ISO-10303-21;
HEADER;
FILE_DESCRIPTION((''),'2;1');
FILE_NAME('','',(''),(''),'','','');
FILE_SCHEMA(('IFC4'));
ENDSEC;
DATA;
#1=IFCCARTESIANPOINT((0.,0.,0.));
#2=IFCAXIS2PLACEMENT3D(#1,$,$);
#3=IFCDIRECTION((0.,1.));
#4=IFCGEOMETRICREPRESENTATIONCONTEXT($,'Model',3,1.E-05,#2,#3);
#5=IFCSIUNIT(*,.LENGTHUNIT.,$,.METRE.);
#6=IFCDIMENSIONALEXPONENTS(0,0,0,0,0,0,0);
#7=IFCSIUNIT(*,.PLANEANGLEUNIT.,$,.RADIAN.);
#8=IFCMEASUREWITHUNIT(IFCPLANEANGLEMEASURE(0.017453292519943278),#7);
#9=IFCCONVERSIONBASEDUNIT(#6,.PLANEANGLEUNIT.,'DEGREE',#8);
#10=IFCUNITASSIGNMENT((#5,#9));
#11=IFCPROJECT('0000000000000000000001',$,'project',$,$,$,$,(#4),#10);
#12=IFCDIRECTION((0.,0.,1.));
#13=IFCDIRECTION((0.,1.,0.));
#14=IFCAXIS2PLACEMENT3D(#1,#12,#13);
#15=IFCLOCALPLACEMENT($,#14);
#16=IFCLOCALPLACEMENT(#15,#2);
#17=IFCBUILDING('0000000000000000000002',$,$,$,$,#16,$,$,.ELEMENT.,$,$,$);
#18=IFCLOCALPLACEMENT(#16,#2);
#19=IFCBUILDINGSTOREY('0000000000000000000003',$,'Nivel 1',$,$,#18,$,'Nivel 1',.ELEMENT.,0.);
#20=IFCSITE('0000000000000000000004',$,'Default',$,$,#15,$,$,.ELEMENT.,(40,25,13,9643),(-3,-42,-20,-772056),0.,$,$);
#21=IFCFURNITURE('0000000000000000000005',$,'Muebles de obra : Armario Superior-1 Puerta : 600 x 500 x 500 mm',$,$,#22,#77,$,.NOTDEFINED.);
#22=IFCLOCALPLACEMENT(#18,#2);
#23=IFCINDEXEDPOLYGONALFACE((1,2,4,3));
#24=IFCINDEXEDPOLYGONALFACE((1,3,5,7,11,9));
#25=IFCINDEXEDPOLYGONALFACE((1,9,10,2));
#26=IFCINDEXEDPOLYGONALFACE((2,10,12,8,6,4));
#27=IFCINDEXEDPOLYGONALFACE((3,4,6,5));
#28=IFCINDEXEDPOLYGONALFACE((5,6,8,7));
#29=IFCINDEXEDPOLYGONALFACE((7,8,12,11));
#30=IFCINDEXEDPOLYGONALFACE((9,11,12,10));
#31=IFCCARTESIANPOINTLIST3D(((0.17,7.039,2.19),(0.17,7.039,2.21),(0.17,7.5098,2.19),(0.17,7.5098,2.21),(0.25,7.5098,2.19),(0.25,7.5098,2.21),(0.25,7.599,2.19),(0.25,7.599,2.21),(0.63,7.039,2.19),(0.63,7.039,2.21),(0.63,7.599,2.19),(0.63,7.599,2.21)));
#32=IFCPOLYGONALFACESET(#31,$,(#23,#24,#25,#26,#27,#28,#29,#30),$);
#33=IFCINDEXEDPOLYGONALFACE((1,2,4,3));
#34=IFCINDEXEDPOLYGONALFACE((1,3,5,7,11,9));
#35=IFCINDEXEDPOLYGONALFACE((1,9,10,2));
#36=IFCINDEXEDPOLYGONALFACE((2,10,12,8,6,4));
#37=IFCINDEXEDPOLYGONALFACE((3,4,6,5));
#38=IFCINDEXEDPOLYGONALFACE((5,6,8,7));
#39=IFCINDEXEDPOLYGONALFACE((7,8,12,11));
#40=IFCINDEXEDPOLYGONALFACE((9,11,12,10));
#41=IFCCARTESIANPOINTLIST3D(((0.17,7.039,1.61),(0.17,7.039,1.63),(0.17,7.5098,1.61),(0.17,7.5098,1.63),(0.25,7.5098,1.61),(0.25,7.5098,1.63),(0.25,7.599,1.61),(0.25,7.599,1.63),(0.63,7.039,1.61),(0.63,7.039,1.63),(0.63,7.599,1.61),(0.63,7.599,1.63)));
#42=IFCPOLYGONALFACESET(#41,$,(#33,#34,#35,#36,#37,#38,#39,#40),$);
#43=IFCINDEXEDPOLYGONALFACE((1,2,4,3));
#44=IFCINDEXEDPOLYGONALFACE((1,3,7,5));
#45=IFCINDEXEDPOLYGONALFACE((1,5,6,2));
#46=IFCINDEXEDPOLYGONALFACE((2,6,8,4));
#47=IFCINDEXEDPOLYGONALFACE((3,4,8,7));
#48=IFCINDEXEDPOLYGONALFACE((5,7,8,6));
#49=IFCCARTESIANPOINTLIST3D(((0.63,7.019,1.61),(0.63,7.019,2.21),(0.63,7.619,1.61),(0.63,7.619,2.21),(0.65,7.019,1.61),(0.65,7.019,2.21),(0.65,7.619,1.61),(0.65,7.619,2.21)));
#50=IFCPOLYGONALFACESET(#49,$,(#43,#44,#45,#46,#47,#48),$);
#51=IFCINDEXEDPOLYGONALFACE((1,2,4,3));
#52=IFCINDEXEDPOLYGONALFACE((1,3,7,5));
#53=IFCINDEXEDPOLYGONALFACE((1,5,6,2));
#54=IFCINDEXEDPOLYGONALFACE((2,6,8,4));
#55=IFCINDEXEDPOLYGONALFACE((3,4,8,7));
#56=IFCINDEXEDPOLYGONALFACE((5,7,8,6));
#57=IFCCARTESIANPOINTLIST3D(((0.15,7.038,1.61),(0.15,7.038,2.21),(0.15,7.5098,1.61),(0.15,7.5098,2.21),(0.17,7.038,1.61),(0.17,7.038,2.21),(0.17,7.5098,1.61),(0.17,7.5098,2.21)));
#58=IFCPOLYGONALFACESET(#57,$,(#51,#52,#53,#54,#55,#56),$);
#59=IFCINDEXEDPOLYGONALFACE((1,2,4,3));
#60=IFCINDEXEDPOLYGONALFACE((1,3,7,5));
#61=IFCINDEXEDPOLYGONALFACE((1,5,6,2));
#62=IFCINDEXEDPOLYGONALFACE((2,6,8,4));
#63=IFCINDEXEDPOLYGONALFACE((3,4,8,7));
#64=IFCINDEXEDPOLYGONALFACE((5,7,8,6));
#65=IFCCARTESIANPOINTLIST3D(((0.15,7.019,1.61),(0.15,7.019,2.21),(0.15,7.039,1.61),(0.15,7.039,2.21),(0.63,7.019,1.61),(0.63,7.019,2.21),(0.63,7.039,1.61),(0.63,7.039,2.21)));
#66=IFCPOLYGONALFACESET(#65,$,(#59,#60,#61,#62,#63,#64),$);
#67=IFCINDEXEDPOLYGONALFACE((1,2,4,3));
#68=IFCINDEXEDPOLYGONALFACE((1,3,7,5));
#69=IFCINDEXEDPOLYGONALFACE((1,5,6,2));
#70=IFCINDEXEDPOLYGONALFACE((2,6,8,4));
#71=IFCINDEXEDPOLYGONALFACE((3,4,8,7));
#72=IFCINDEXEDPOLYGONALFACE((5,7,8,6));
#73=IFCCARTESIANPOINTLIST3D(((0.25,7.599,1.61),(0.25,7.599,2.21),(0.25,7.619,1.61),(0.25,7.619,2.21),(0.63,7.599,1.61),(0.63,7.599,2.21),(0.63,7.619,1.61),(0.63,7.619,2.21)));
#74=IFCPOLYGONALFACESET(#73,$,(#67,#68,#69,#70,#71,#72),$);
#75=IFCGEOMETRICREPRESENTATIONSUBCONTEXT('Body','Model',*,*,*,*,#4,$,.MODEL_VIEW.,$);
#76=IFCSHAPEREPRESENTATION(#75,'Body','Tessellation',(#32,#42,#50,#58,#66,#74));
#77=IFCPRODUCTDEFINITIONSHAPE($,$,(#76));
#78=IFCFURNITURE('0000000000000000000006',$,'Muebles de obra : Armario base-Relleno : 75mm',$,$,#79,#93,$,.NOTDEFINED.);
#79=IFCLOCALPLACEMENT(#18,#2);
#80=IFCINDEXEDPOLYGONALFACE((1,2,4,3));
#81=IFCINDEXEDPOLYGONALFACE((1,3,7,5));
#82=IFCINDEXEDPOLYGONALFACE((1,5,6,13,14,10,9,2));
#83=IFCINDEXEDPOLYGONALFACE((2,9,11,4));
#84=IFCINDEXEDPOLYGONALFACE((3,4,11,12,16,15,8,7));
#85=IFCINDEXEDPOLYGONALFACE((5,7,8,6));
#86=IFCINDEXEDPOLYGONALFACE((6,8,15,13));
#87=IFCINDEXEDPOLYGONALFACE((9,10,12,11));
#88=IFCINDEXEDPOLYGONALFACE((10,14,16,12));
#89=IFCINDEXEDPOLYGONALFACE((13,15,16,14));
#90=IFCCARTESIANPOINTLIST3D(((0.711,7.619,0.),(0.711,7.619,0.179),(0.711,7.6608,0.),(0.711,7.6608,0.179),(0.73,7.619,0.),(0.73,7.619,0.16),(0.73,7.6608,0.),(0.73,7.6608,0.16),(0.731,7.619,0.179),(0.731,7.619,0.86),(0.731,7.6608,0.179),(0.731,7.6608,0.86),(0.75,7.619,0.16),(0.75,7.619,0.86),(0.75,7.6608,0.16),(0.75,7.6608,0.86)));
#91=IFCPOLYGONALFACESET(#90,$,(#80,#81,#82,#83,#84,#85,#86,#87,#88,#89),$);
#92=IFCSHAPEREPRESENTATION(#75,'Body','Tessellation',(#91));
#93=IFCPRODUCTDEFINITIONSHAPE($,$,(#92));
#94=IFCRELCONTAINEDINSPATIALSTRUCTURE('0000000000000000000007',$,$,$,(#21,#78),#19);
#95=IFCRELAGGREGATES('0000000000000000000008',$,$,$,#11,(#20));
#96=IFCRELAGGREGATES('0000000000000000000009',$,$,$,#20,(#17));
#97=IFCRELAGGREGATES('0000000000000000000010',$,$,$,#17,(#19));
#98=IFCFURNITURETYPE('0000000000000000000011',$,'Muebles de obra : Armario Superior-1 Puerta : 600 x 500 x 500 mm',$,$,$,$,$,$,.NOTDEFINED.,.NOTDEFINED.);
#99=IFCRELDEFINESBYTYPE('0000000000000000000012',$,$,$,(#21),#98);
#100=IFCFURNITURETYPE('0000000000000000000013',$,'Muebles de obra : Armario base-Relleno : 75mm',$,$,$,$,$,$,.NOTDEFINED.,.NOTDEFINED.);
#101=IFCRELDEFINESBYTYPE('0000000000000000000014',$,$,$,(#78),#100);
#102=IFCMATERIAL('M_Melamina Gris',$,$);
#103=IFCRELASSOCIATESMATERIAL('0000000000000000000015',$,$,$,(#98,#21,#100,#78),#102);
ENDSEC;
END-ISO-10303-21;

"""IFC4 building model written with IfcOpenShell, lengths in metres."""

from ifc_helpers import new_model, entity, si_unit, converted_unit, direction, frame, origin, place, context, subcontext, project, spatial, indexed_curve, outline, extrude, source, transform, mapped, material, type_object, type_shapes, element, save


model = new_model("IFC4")

# Units and contexts
model_context = context("Model", 3, precision=1e-05, world=origin(), true_north=direction((0.0, 1.0)))
body_context = subcontext(model_context, "Body", "Model", "MODEL_VIEW")
ifc_project = project(units=[si_unit("LENGTHUNIT", "METRE"), converted_unit("PLANEANGLEUNIT", "DEGREE", entity("IfcPlaneAngleMeasure", 0.017453292519943278), si_unit("PLANEANGLEUNIT", "RADIAN"), dimensions=[0, 0, 0, 0, 0, 0, 0])], contexts=[model_context])

# Site, building, storey
site_placement = place(None, frame((0.0, 0.0, 0.0), z_axis=(0.0, 0.0, 1.0), x_axis=(0.0, 1.0, 0.0)))
site = spatial("IfcSite", under=ifc_project, at=site_placement, Name="Default", CompositionType="ELEMENT", RefLatitude=(40, 25, 13, 9643), RefLongitude=(-3, -42, -20, -772056), RefElevation=0.0)
building_placement = place(site_placement, origin())
building = spatial("IfcBuilding", under=site, at=building_placement, CompositionType="ELEMENT")
storey_placement = place(building_placement, origin())
storey = spatial("IfcBuildingStorey", under=building, at=storey_placement, Name="Nivel 1", LongName="Nivel 1", CompositionType="ELEMENT", Elevation=0.0)

# Furniture
ifc_material_1 = material(Name="M_Melamina Gris")
furniture_type_1 = type_object("IfcFurnitureType", Name="Muebles de obra : Armario Superior-1 Puerta : 600 x 500 x 500 mm", AssemblyPlace="NOTDEFINED", PredefinedType="NOTDEFINED", material=ifc_material_1)
shared_shape_1 = source(origin(), body_context, "Body", "SweptSolid", [
    extrude(outline(indexed_curve([(-0.28, -0.2164), (0.1, -0.2164), (0.1, -0.1272), (0.18, -0.1272), (0.18, 0.3436), (-0.28, 0.3436), (-0.28, -0.2164)], self_intersect=False)), frame((0.35, 7.3826, 2.19), z_axis=(0.0, 0.0, 1.0), x_axis=(-1.0, 0.0, 0.0)), (0.0, 0.0, 1.0), 0.02),
    extrude(outline(indexed_curve([(-0.28, -0.2164), (0.1, -0.2164), (0.1, -0.1272), (0.18, -0.1272), (0.18, 0.3436), (-0.28, 0.3436), (-0.28, -0.2164)], self_intersect=False)), frame((0.35, 7.3826, 1.61), z_axis=(0.0, 0.0, 1.0), x_axis=(-1.0, 0.0, 0.0)), (0.0, 0.0, 1.0), 0.02),
    extrude(outline(indexed_curve([(-0.3, -0.01), (0.3, -0.01), (0.3, 0.01), (-0.3, 0.01), (-0.3, -0.01)], self_intersect=False)), frame((0.64, 7.319, 1.61), z_axis=(0.0, 0.0, 1.0), x_axis=(0.0, -1.0, 0.0)), (0.0, 0.0, 1.0), 0.6),
    extrude(outline(indexed_curve([(-0.2359, -0.01), (0.2359, -0.01), (0.2359, 0.01), (-0.2359, 0.01), (-0.2359, -0.01)], self_intersect=False)), frame((0.16, 7.2739, 1.61), z_axis=(0.0, 0.0, 1.0), x_axis=(0.0, 1.0, 0.0)), (0.0, 0.0, 1.0), 0.6),
    extrude(outline(indexed_curve([(-0.24, -0.01), (0.24, -0.01), (0.24, 0.01), (-0.24, 0.01), (-0.24, -0.01)], self_intersect=False)), frame((0.39, 7.029, 1.61), z_axis=(0.0, 0.0, 1.0), x_axis=(-1.0, 0.0, 0.0)), (0.0, 0.0, 1.0), 0.6),
    extrude(outline(indexed_curve([(-0.19, -0.01), (0.19, -0.01), (0.19, 0.01), (-0.19, 0.01), (-0.19, -0.01)], self_intersect=False)), frame((0.44, 7.609, 1.61), z_axis=(0.0, 0.0, 1.0), x_axis=(-1.0, 0.0, 0.0)), (0.0, 0.0, 1.0), 0.6),
])
type_shapes(furniture_type_1, [shared_shape_1])
furniture_1_placement = place(storey_placement, origin())
element("IfcFurniture", 1, at=furniture_1_placement, inside=storey, type_object=furniture_type_1, material=ifc_material_1, Name="Muebles de obra : Armario Superior-1 Puerta : 600 x 500 x 500 mm", PredefinedType="NOTDEFINED", context=body_context, shape_type="MappedRepresentation", body=[
    mapped(shared_shape_1, transform((0.0, 0.0, 0.0), scale=1.0)),
])
furniture_type_2 = type_object("IfcFurnitureType", Name="Muebles de obra : Armario base-Relleno : 75mm", AssemblyPlace="NOTDEFINED", PredefinedType="NOTDEFINED", material=ifc_material_1)
shared_shape_2 = source(origin(), body_context, "Body", "SweptSolid", [
    extrude(outline(indexed_curve([(-0.0195, 0.1398), (-0.0195, -0.5602), (-0.0005, -0.5602), (-0.0005, 0.1207), (0.0195, 0.1207), (0.0195, 0.2998), (0.0005, 0.2998), (0.0005, 0.1398), (-0.0195, 0.1398)], self_intersect=False)), frame((0.7305, 7.619, 0.2998), z_axis=(0.0, -1.0, 0.0), x_axis=(-1.0, 0.0, 0.0)), (0.0, 0.0, -1.0), 0.0418),
])
type_shapes(furniture_type_2, [shared_shape_2])
furniture_2_placement = place(storey_placement, origin())
element("IfcFurniture", 2, at=furniture_2_placement, inside=storey, type_object=furniture_type_2, material=ifc_material_1, Name="Muebles de obra : Armario base-Relleno : 75mm", PredefinedType="NOTDEFINED", context=body_context, shape_type="MappedRepresentation", body=[
    mapped(shared_shape_2, transform((0.0, 0.0, 0.0), scale=1.0)),
])

save(model, "model.ifc")
